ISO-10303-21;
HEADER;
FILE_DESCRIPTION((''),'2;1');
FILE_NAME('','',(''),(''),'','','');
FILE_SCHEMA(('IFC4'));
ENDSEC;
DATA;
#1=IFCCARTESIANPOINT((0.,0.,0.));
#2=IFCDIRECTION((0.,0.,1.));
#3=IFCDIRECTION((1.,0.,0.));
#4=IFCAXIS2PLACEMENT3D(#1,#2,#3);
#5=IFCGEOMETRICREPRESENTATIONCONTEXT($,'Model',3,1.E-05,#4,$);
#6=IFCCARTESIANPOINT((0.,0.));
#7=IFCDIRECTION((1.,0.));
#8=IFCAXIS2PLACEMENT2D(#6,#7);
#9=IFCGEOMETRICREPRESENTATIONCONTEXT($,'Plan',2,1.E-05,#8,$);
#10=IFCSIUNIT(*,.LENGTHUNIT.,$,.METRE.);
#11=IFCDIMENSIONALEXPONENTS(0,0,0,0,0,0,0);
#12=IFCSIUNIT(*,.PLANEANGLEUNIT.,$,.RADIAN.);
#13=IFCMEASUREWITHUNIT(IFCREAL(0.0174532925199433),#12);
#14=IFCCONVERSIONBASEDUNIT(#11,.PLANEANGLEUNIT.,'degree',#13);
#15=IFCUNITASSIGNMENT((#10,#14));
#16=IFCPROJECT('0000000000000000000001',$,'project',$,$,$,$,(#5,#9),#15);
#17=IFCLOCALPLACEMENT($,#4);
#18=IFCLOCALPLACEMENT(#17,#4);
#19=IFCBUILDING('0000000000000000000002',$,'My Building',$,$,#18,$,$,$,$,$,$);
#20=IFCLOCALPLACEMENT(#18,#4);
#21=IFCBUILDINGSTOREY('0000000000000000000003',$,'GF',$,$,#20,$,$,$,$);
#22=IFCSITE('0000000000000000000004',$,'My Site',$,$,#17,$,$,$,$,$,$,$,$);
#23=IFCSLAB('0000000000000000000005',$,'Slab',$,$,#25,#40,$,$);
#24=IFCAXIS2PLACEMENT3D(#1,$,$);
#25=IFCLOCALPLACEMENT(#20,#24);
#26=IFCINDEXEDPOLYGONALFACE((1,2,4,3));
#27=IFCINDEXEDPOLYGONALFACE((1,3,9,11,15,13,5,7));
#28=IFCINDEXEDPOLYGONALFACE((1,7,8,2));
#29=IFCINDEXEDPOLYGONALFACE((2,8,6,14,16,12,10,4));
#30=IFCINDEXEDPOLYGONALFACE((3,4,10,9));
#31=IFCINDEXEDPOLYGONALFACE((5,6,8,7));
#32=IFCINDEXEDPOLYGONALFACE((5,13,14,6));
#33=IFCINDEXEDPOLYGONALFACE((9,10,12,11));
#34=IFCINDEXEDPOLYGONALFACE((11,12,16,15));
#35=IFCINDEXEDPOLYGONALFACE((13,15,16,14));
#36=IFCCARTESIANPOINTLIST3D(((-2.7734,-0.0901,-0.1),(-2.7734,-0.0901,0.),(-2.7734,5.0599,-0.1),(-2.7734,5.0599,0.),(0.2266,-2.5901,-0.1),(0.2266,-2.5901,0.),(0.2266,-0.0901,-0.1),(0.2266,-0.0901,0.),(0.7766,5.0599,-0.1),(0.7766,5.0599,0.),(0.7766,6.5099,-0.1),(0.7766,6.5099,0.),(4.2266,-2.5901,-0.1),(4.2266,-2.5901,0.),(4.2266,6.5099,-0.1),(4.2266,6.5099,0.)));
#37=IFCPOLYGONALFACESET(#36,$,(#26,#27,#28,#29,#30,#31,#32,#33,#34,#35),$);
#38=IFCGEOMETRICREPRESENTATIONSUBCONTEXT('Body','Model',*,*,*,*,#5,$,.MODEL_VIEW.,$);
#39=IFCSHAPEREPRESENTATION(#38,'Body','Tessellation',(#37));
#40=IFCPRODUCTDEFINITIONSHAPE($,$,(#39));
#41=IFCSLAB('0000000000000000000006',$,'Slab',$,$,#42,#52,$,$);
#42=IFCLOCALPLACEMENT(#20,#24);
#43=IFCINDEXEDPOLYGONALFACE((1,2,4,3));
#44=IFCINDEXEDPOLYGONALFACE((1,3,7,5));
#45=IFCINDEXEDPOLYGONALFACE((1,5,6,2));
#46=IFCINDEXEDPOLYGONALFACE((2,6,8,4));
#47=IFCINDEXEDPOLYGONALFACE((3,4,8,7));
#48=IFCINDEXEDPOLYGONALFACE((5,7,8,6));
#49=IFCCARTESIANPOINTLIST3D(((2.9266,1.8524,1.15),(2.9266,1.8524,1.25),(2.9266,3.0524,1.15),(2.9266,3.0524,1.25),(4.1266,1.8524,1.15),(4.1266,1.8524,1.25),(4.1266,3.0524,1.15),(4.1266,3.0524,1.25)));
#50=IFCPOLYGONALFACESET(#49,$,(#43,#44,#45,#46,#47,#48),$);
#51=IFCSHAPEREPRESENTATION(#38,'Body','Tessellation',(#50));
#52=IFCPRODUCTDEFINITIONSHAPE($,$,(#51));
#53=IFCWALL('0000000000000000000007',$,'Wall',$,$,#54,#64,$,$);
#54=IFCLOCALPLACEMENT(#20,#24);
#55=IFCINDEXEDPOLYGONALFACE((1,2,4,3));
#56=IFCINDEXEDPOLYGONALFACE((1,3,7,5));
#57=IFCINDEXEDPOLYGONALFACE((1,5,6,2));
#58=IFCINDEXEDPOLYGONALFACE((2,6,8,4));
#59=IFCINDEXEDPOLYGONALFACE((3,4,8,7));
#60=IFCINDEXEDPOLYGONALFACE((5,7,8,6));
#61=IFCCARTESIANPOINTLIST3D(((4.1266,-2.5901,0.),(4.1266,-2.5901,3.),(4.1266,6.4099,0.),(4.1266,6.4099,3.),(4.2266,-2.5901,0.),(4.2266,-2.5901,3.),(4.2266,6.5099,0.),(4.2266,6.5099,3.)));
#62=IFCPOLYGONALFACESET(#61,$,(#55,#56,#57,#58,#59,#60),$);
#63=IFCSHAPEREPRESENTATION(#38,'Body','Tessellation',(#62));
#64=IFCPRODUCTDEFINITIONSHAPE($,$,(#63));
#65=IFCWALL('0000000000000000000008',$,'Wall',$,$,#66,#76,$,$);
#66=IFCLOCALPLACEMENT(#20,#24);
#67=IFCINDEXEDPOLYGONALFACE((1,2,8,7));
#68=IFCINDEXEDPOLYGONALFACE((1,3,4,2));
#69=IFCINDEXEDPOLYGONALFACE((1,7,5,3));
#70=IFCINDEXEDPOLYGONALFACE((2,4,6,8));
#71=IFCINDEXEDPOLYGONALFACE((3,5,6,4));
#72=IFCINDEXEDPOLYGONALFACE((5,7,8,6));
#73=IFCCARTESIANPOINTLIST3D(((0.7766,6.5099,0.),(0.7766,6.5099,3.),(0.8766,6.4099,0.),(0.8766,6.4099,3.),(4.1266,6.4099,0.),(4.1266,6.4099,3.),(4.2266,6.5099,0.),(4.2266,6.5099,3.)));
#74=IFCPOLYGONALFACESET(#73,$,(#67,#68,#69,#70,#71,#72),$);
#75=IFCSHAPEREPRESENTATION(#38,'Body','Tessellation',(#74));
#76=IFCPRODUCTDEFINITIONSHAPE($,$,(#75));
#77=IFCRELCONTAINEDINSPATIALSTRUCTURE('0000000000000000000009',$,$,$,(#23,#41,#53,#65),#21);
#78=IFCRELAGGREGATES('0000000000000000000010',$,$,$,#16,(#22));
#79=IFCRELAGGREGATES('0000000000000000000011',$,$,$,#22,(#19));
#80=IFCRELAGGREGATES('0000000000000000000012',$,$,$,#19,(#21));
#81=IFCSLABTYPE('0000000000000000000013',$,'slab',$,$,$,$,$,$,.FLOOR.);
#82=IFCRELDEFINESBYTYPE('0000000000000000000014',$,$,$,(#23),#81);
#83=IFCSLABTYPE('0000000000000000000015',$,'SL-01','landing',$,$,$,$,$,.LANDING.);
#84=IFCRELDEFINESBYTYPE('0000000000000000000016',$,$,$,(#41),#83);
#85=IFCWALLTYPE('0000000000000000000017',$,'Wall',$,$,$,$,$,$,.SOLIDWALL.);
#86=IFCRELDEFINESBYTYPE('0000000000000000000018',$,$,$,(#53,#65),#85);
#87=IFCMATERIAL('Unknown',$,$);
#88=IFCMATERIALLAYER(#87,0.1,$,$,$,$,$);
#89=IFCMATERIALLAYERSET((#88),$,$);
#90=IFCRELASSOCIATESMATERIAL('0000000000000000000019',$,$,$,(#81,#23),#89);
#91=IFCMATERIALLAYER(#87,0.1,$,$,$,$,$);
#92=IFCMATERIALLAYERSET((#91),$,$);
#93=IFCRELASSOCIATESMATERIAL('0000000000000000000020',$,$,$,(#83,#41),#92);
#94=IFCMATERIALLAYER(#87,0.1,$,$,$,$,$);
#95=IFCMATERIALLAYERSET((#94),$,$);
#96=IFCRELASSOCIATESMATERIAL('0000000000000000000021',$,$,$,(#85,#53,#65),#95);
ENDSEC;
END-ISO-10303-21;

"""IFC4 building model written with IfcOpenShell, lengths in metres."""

from ifc_helpers import new_model, entity, si_unit, converted_unit, frame, origin_with_axes, origin_2d_with_axis, place, context, subcontext, project, spatial, line, indexed_curve, outline, extrude, material, layer, layer_set, layer_usage, type_object, element, save


model = new_model("IFC4")

# Units and contexts
model_context = context("Model", 3, precision=1e-05, world=origin_with_axes())
plan_context = context("Plan", 2, precision=1e-05, world=origin_2d_with_axis())
body_context_1 = subcontext(model_context, "Body", "Model", "MODEL_VIEW")
ifc_project = project(units=[si_unit("LENGTHUNIT", "METRE"), converted_unit("PLANEANGLEUNIT", "degree", entity("IfcReal", 0.0174532925199433), si_unit("PLANEANGLEUNIT", "RADIAN"), dimensions=[0, 0, 0, 0, 0, 0, 0])], contexts=[model_context, plan_context])

# Site, building, storey
site_placement = place(None, origin_with_axes())
site = spatial("IfcSite", under=ifc_project, at=site_placement, Name="My Site")
building_placement = place(site_placement, origin_with_axes())
building = spatial("IfcBuilding", under=site, at=building_placement, Name="My Building")
storey_placement = place(building_placement, origin_with_axes())
storey = spatial("IfcBuildingStorey", under=building, at=storey_placement, Name="GF")

# Slabs
ifc_material_1 = material(Name="Unknown")
ifc_layer_1 = layer(ifc_material_1, 0.1)
ifc_layer_set_1 = layer_set([ifc_layer_1])
ifc_layer_usage_1 = layer_usage(ifc_layer_set_1, "AXIS3", "POSITIVE", -0.1)
slab_type_1 = type_object("IfcSlabType", Name="slab", PredefinedType="FLOOR", material=ifc_layer_set_1)
slab_1_placement = place(storey_placement, frame((4.2266, -2.5901, 0.0), z_axis=(0.0, 0.0, 1.0), x_axis=(1.0, 0.0, 0.0)))
element("IfcSlab", 1, at=slab_1_placement, inside=storey, type_object=slab_type_1, material=ifc_layer_usage_1, Name="Slab", context=body_context_1, shape_type="SweptSolid", body=[
    extrude(outline(indexed_curve([(0.0, 0.0), (0.0, 9.1), (-3.45, 9.1), (-3.45, 7.65), (-7.0, 7.65), (-7.0, 2.5), (-4.0, 2.5), (-4.0, 0.0), (0.0, 0.0)])), frame((0.0, 0.0, -0.1), z_axis=(0.0, 0.0, 1.0), x_axis=(1.0, 0.0, 0.0)), (0.0, 0.0, 1.0), 0.1),
])
ifc_layer_2 = layer(ifc_material_1, 0.1)
ifc_layer_set_2 = layer_set([ifc_layer_2])
ifc_layer_usage_2 = layer_usage(ifc_layer_set_2, "AXIS3", "POSITIVE", -0.1)
slab_type_2 = type_object("IfcSlabType", Name="SL-01", Description="landing", PredefinedType="LANDING", material=ifc_layer_set_2)
slab_2_placement = place(storey_placement, frame((2.9266, 3.0524, 1.25), z_axis=(0.0, 0.0, 1.0), x_axis=(1.0, 0.0, 0.0)))
element("IfcSlab", 2, at=slab_2_placement, inside=storey, type_object=slab_type_2, material=ifc_layer_usage_2, Name="Slab", context=body_context_1, shape_type="SweptSolid", body=[
    extrude(outline(indexed_curve([(0.0, 0.0), (0.0, -1.2), (1.2, -1.2), (1.2, 0.0), (0.0, 0.0)])), frame((0.0, 0.0, -0.1), z_axis=(0.0, 0.0, 1.0), x_axis=(1.0, 0.0, 0.0)), (0.0, 0.0, 1.0), 0.1),
])

# Shared definitions
ifc_layer_3 = layer(ifc_material_1, 0.1)
ifc_layer_set_3 = layer_set([ifc_layer_3])
wall_type = type_object("IfcWallType", Name="Wall", PredefinedType="SOLIDWALL", material=ifc_layer_set_3)

# Walls
ifc_layer_usage_3 = layer_usage(ifc_layer_set_3, "AXIS2", "POSITIVE", 0.0)
wall_1_placement = place(storey_placement, frame((4.2266, -2.5901, 0.0), z_axis=(0.0, 0.0, 1.0), x_axis=(0.0, 1.0, 0.0)))
element("IfcWall", 3, at=wall_1_placement, inside=storey, type_object=wall_type, material=ifc_layer_usage_3, Name="Wall", context=body_context_1, shape_type="SweptSolid", body=[
    extrude(outline(indexed_curve([(0.0, 0.0), (0.0, 0.1), (9.0, 0.1), (9.1, 0.0)], segments=[line(1, 2, 3, 4, 1)])), origin_with_axes(), (0.0, 0.0, 1.0), 3.0),
])
ifc_layer_usage_4 = layer_usage(ifc_layer_set_3, "AXIS2", "POSITIVE", 0.0)
wall_2_placement = place(storey_placement, frame((4.2266, 6.5099, 0.0), z_axis=(0.0, 0.0, 1.0), x_axis=(-1.0, 0.0, 0.0)))
element("IfcWall", 4, at=wall_2_placement, inside=storey, type_object=wall_type, material=ifc_layer_usage_4, Name="Wall", context=body_context_1, shape_type="SweptSolid", body=[
    extrude(outline(indexed_curve([(0.0, 0.0), (0.1, 0.1), (3.35, 0.1), (3.45, 0.0)], segments=[line(1, 2, 3, 4, 1)])), origin_with_axes(), (0.0, 0.0, 1.0), 3.0),
])

save(model, "model.ifc")
